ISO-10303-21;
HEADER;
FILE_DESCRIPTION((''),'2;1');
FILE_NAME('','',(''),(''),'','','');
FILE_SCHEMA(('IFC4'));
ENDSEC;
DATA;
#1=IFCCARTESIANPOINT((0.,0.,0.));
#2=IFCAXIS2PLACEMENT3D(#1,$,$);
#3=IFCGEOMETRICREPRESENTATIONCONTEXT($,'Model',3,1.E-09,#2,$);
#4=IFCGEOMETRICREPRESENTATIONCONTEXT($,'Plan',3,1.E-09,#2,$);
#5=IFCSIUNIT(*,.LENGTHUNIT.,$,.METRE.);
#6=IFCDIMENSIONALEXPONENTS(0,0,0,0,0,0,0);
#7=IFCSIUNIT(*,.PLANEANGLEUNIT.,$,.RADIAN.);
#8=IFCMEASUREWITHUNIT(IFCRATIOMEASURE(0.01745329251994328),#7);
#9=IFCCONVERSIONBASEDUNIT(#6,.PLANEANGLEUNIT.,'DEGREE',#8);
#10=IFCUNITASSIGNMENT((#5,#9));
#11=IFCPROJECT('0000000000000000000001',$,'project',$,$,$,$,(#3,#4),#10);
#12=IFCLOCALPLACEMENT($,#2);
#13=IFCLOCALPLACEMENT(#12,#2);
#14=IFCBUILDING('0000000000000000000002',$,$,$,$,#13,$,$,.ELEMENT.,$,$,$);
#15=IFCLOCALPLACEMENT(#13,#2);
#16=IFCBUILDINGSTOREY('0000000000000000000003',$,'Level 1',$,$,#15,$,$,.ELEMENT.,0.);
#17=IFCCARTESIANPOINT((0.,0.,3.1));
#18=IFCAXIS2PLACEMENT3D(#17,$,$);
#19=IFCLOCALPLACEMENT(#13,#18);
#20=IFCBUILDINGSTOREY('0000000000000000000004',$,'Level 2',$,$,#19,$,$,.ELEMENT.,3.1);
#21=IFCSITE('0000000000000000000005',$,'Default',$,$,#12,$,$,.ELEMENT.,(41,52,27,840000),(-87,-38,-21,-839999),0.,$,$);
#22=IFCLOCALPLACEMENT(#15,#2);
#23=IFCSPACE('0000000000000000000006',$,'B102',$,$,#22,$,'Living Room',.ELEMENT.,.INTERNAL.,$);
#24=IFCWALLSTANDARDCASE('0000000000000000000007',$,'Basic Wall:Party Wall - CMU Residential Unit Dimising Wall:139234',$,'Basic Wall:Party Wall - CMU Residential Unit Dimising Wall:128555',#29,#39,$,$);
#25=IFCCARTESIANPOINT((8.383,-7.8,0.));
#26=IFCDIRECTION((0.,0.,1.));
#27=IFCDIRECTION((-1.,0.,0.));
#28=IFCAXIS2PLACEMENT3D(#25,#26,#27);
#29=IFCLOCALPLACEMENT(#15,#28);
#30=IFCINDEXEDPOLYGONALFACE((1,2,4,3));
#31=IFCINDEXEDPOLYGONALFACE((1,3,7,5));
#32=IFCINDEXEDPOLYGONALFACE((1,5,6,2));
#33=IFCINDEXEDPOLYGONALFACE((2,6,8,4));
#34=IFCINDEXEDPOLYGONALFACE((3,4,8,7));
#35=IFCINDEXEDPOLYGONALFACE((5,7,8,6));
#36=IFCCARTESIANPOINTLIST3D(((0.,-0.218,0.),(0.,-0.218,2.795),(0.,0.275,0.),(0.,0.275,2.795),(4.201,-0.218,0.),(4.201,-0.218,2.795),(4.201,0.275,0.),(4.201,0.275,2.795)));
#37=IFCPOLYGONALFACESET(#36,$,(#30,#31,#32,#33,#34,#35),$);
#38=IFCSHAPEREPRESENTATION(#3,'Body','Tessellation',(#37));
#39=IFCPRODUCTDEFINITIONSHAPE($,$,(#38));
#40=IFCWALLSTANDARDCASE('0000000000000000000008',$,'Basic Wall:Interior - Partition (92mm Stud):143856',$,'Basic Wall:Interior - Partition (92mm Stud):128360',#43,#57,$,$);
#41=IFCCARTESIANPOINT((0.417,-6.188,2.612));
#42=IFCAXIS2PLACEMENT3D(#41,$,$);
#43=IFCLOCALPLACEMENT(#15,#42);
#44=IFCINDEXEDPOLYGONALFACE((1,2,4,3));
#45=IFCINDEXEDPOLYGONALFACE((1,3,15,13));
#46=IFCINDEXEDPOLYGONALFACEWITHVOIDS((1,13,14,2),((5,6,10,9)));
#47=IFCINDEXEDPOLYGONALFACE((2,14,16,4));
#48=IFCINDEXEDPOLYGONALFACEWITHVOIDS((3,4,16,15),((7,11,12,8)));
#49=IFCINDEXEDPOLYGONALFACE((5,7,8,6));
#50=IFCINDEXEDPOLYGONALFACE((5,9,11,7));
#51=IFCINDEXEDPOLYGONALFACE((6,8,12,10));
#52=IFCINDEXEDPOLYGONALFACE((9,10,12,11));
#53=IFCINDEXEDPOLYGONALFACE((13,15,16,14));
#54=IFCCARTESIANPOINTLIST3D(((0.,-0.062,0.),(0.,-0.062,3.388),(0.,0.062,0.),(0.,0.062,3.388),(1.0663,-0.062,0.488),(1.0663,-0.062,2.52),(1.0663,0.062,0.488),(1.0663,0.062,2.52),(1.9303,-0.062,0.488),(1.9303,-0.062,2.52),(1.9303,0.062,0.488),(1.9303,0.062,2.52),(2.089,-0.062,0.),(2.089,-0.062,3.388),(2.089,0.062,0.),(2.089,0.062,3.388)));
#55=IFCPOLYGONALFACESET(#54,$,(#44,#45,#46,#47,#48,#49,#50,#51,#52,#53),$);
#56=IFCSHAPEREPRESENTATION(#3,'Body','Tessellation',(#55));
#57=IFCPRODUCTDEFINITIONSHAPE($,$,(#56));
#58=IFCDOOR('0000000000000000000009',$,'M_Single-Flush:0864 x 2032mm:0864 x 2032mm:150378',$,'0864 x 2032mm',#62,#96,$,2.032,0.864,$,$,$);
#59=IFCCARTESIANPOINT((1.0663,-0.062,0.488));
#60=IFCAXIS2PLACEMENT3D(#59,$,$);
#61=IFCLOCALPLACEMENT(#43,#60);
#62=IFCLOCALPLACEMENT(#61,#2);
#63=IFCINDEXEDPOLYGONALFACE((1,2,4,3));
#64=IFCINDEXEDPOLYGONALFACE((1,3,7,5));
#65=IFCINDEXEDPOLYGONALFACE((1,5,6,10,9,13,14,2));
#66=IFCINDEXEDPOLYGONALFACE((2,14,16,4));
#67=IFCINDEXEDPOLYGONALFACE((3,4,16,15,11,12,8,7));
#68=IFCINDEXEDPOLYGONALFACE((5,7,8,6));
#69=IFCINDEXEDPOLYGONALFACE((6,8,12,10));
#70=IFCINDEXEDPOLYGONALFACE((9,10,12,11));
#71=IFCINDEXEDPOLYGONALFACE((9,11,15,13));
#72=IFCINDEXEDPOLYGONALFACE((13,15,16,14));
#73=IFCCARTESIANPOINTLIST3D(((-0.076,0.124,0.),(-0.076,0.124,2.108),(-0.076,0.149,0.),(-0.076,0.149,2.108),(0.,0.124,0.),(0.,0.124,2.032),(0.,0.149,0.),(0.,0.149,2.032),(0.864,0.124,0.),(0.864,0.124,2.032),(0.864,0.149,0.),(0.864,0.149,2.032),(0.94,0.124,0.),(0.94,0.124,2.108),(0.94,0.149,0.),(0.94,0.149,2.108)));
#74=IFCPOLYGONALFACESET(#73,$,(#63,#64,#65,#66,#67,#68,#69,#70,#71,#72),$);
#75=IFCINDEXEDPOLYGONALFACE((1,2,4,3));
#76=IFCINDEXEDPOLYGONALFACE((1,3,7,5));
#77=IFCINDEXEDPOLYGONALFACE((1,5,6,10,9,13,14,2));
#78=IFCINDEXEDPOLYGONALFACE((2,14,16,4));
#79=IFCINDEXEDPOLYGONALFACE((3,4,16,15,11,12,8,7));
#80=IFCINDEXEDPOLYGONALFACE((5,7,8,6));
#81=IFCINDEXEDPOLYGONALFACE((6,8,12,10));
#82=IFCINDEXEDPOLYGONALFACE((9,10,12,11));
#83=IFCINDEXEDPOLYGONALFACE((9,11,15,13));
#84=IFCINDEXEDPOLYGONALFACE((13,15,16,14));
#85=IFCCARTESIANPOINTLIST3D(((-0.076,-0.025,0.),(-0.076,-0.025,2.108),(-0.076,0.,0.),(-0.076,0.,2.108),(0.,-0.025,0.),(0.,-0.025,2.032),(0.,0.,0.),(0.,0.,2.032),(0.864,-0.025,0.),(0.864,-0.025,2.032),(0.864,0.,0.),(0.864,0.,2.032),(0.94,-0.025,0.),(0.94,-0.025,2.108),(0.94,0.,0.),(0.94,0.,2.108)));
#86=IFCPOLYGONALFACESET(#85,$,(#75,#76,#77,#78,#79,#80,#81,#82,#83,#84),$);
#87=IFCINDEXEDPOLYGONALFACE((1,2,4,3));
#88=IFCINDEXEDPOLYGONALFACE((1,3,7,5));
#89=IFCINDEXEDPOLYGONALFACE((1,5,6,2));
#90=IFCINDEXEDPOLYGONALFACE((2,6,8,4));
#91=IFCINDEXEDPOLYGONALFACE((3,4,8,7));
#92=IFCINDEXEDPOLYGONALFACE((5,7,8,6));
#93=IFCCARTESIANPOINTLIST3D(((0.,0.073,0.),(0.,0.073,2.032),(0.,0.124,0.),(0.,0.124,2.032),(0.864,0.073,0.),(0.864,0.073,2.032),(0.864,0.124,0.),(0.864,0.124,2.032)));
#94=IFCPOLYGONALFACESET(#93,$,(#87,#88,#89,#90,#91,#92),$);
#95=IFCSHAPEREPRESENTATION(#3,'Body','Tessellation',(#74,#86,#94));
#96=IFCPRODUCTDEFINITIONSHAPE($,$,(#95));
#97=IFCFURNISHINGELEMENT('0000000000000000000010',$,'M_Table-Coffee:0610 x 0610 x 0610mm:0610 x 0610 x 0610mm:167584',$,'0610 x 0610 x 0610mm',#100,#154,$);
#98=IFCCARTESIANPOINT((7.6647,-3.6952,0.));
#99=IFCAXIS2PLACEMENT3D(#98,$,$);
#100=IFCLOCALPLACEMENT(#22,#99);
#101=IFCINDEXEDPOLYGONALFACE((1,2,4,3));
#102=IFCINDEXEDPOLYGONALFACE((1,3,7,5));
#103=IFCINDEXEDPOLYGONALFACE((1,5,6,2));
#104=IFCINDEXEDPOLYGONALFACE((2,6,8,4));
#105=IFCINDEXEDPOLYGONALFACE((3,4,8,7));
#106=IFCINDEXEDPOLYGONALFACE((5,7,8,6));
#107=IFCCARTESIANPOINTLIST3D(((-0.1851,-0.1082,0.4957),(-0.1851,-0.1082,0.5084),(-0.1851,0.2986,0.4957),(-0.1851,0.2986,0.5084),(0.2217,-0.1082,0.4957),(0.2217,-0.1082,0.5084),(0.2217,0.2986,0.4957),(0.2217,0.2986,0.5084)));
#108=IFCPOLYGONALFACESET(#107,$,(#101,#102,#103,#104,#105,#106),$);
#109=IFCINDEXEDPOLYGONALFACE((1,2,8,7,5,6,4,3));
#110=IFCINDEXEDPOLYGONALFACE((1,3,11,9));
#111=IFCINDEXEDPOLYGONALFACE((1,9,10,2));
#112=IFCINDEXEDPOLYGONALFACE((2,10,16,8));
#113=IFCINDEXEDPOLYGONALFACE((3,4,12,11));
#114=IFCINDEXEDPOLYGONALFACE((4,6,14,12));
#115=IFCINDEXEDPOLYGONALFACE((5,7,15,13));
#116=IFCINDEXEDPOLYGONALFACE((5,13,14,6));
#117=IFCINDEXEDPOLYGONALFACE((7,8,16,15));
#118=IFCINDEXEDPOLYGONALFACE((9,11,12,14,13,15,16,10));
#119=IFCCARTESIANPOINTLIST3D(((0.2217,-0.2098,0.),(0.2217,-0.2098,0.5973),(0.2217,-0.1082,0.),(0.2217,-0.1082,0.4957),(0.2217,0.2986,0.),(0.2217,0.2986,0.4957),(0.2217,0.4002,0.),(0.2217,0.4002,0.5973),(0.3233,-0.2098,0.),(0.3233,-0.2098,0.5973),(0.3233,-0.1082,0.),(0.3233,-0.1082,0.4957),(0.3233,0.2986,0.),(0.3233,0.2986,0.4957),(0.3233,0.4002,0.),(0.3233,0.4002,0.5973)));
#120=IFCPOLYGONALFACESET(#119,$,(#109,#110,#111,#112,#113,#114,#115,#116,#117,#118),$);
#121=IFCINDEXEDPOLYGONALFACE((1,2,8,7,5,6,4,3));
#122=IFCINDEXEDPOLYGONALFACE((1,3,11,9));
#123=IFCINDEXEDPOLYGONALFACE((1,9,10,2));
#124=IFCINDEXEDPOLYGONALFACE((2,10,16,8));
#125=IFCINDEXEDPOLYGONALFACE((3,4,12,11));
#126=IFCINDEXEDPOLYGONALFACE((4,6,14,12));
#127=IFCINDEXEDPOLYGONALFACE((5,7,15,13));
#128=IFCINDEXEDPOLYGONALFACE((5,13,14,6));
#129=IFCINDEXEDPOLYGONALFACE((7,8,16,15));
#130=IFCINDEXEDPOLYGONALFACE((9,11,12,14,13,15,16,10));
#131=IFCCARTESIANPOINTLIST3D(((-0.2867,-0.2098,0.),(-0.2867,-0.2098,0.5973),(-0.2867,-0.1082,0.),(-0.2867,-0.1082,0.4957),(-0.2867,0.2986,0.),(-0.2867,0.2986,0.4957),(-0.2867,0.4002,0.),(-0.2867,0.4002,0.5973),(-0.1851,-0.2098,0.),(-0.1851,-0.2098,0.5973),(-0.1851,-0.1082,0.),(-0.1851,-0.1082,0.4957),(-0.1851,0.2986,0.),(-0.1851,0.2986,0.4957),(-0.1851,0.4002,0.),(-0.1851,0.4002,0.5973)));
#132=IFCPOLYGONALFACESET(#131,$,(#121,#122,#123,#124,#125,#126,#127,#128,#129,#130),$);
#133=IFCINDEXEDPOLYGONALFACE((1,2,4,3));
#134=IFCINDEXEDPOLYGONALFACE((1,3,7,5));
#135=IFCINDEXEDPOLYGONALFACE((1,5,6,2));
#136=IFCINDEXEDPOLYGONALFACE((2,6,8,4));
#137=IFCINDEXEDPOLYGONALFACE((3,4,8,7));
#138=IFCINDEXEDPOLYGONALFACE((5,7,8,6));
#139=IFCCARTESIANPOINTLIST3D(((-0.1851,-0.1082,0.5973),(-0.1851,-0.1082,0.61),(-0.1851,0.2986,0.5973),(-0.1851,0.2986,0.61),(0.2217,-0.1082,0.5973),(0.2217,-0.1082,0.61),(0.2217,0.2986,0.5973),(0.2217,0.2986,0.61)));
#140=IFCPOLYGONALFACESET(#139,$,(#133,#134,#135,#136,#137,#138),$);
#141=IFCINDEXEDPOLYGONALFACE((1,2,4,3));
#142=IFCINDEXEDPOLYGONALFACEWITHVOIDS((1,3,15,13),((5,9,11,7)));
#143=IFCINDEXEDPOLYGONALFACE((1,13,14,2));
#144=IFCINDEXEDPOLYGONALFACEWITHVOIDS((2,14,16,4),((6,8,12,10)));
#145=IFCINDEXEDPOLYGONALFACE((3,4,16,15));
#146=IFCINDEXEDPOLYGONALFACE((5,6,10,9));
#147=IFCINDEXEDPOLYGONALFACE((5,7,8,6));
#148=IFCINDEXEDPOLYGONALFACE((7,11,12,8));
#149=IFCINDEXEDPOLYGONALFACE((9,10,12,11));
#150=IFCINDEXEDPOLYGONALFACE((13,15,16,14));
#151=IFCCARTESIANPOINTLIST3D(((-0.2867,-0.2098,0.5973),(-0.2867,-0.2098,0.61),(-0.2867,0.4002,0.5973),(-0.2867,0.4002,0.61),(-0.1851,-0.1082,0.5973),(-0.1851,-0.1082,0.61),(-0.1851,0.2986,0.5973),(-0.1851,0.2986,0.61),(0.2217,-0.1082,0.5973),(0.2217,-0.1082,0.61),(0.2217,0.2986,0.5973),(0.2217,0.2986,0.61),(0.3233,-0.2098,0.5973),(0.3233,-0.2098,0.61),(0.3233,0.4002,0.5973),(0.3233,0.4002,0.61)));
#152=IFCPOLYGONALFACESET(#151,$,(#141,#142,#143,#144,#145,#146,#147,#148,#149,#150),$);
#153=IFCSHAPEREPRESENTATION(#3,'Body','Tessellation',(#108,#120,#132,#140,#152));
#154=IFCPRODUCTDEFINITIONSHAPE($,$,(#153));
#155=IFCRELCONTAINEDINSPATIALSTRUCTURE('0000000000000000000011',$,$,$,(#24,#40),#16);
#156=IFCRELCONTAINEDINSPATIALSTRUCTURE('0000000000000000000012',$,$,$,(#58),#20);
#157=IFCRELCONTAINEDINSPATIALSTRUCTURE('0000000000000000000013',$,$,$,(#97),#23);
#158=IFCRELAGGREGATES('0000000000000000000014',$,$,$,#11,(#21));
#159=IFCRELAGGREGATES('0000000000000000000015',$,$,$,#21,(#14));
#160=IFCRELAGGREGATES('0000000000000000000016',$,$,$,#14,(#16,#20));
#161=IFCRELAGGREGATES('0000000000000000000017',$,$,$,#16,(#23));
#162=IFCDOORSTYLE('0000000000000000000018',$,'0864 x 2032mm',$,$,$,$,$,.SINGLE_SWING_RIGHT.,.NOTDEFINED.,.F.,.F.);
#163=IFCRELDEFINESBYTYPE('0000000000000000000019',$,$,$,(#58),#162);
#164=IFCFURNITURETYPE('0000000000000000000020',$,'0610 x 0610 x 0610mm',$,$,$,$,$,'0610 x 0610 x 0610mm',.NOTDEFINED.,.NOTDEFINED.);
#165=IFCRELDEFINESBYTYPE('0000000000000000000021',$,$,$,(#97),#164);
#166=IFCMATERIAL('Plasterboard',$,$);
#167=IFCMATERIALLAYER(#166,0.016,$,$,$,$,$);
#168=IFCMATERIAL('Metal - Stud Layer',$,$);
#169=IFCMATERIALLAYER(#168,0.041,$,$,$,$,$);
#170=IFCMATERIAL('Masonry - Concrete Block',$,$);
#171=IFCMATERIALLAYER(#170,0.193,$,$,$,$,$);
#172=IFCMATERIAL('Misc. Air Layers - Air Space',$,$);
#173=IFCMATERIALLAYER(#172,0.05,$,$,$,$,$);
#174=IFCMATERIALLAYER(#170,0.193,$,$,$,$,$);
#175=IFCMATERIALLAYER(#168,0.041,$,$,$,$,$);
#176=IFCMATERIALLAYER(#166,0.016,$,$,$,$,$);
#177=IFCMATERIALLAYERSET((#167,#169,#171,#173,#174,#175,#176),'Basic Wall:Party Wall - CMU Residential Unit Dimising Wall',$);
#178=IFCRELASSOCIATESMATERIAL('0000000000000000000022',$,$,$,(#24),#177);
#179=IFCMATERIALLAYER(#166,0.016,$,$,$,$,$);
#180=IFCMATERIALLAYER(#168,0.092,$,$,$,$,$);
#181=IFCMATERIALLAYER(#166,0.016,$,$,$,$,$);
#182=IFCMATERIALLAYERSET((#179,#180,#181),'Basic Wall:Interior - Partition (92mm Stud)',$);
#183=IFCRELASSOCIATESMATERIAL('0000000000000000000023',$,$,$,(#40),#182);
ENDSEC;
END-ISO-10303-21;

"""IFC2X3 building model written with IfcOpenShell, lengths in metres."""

from ifc_helpers import new_model, entity, si_unit, converted_unit, frame, frame_2d, origin, origin_2d_with_axis, place, context, project, spatial, polyline, rectangle, outline, extrude, clip, bounded_halfspace, source, transform, mapped, material, layer, layer_set, layer_usage, type_object, type_shapes, element, fill, save


model = new_model("IFC2X3")

# Units and contexts
model_context_1 = context("Model", 3, precision=1e-09, world=origin())
plan_context = context("Plan", 3, precision=1e-09, world=origin())
ifc_project = project(units=[si_unit("LENGTHUNIT", "METRE"), converted_unit("PLANEANGLEUNIT", "DEGREE", entity("IfcRatioMeasure", 0.01745329251994328), si_unit("PLANEANGLEUNIT", "RADIAN"), dimensions=[0, 0, 0, 0, 0, 0, 0])], contexts=[model_context_1, plan_context])

# Site, building, storey
site_placement = place(None, origin())
site = spatial("IfcSite", under=ifc_project, at=site_placement, Name="Default", CompositionType="ELEMENT", RefLatitude=(41, 52, 27, 840000), RefLongitude=(-87, -38, -21, -839999), RefElevation=0.0)
building_placement = place(site_placement, origin())
building = spatial("IfcBuilding", under=site, at=building_placement, CompositionType="ELEMENT")
storey_1_placement = place(building_placement, origin())
storey_1 = spatial("IfcBuildingStorey", under=building, at=storey_1_placement, Name="Level 1", CompositionType="ELEMENT", Elevation=0.0)

# Shared definitions
ifc_material_1 = material(Name="Misc. Air Layers - Air Space")
ifc_material_2 = material(Name="Masonry - Concrete Block")
ifc_material_3 = material(Name="Metal - Stud Layer")
ifc_material_4 = material(Name="Plasterboard")

# Shared definitions
ifc_layer_1 = layer(ifc_material_4, 0.016)
ifc_layer_2 = layer(ifc_material_3, 0.092)
ifc_layer_3 = layer(ifc_material_4, 0.016)
ifc_layer_set_1 = layer_set([ifc_layer_1, ifc_layer_2, ifc_layer_3], Name="Basic Wall:Interior - Partition (92mm Stud)")

# Wall
ifc_layer_4 = layer(ifc_material_4, 0.016)
ifc_layer_5 = layer(ifc_material_3, 0.041)
ifc_layer_6 = layer(ifc_material_2, 0.193)
ifc_layer_7 = layer(ifc_material_1, 0.05)
ifc_layer_8 = layer(ifc_material_2, 0.193)
ifc_layer_9 = layer(ifc_material_3, 0.041)
ifc_layer_10 = layer(ifc_material_4, 0.016)
ifc_layer_set_2 = layer_set([ifc_layer_4, ifc_layer_5, ifc_layer_6, ifc_layer_7, ifc_layer_8, ifc_layer_9, ifc_layer_10], Name="Basic Wall:Party Wall - CMU Residential Unit Dimising Wall")
ifc_layer_usage_1 = layer_usage(ifc_layer_set_2, "AXIS2", "NEGATIVE", 0.275)
wall_1_placement = place(storey_1_placement, frame((8.383, -7.8, 0.0), z_axis=(0.0, 0.0, 1.0), x_axis=(-1.0, 0.0, 0.0)))
element("IfcWallStandardCase", 1, at=wall_1_placement, inside=storey_1, material=ifc_layer_usage_1, Name="Basic Wall:Party Wall - CMU Residential Unit Dimising Wall:139234", ObjectType="Basic Wall:Party Wall - CMU Residential Unit Dimising Wall:128555", context=model_context_1, shape_type="Clipping", body=[
    clip(clip(extrude(rectangle(XDim=4.201, YDim=0.55, at=frame_2d((2.1005, 0.0), x_axis=(-1.0, 0.0))), origin(), (0.0, 0.0, 1.0), 2.795), bounded_halfspace(frame((0.0, -0.218, 2.795), z_axis=(0.0, 1.0, 0.0), x_axis=(-1.0, 0.0, 0.0)), True, frame((0.0, -0.218, 2.795), z_axis=(0.0, 1.0, 0.0), x_axis=(-1.0, 0.0, 0.0)), polyline([(0.0, 0.0), (-3.708, 0.0), (-4.201, 0.0), (-4.201, -2.795), (0.0, -2.795), (0.0, 0.0)]))), bounded_halfspace(frame((4.201, 0.275, 0.0), z_axis=(-1.0, 0.0, 0.0), x_axis=(0.0, -1.0, 0.0)), True, frame((4.201, 0.275, 0.0), z_axis=(-1.0, 0.0, 0.0), x_axis=(0.0, -1.0, 0.0)), polyline([(0.0, 0.0), (0.493, 0.0), (0.493, 2.795), (0.0, 2.795), (0.0, 0.0)]))),
])

# Wall, opening
ifc_layer_usage_2 = layer_usage(ifc_layer_set_1, "AXIS2", "NEGATIVE", 0.062)
wall_2_placement = place(storey_1_placement, frame((0.417, -6.188, 2.612)))
wall_2 = element("IfcWallStandardCase", 2, at=wall_2_placement, inside=storey_1, material=ifc_layer_usage_2, Name="Basic Wall:Interior - Partition (92mm Stud):143856", ObjectType="Basic Wall:Interior - Partition (92mm Stud):128360", context=model_context_1, shape_type="SweptSolid", body=[
    extrude(rectangle(XDim=2.089, YDim=0.124, at=frame_2d((1.0445, 0.0), x_axis=(-1.0, 0.0))), origin(), (0.0, 0.0, 1.0), 3.388),
])
opening_1_placement = place(wall_2_placement, frame((1.0663, -0.062, 0.488)))
opening_1 = element("IfcOpeningElement", 3, at=opening_1_placement, cuts=wall_2, ObjectType="Opening", context=model_context_1, shape_type="SweptSolid", body=[
    extrude(rectangle(XDim=0.864, YDim=2.032, at=frame_2d((1.016, 0.432), x_axis=(0.0, 1.0))), frame((0.0, 0.0, 0.0), z_axis=(0.0, 1.0, 0.0), x_axis=(0.0, 0.0, 1.0)), (0.0, 0.0, 1.0), 0.124),
])

# Shared definitions
storey_2_placement = place(building_placement, frame((0.0, 0.0, 3.1)))
storey_2 = spatial("IfcBuildingStorey", under=building, at=storey_2_placement, Name="Level 2", CompositionType="ELEMENT", Elevation=3.1)

# Door
door_style_1 = type_object("IfcDoorStyle", Name="0864 x 2032mm", ConstructionType="NOTDEFINED", OperationType="SINGLE_SWING_RIGHT", ParameterTakesPrecedence=False, Sizeable=False)
shared_shape_1 = source(origin(), model_context_1, "Body", "SweptSolid", [
    extrude(outline(polyline([(-0.508, -1.073), (0.508, -1.073), (0.508, 1.035), (0.432, 1.035), (0.432, -0.997), (-0.432, -0.997), (-0.432, 1.035), (-0.508, 1.035), (-0.508, -1.073)])), frame((0.432, 0.124, 1.035), z_axis=(0.0, 1.0, 0.0), x_axis=(1.0, 0.0, 0.0)), (0.0, 0.0, 1.0), 0.025),
    extrude(outline(polyline([(-1.073, -0.508), (1.035, -0.508), (1.035, -0.432), (-0.997, -0.432), (-0.997, 0.432), (1.035, 0.432), (1.035, 0.508), (-1.073, 0.508), (-1.073, -0.508)])), frame((0.432, -0.025, 1.035), z_axis=(0.0, 1.0, 0.0), x_axis=(0.0, 0.0, -1.0)), (0.0, 0.0, 1.0), 0.025),
    extrude(rectangle(XDim=0.051, YDim=0.864, at=origin_2d_with_axis()), frame((0.432, 0.0985, 0.0), z_axis=(0.0, 0.0, 1.0), x_axis=(0.0, 1.0, 0.0)), (0.0, 0.0, 1.0), 2.032),
])
type_shapes(door_style_1, [shared_shape_1])
door_1_placement = place(opening_1_placement, origin())
door_1 = element("IfcDoor", 4, at=door_1_placement, inside=storey_2, type_object=door_style_1, Name="M_Single-Flush:0864 x 2032mm:0864 x 2032mm:150378", ObjectType="0864 x 2032mm", OverallHeight=2.032, OverallWidth=0.864, context=model_context_1, shape_type="MappedRepresentation", body=[
    mapped(shared_shape_1, transform((0.0, 0.0, 0.0), scale=1.0)),
])
fill(opening_1, door_1)

# Shared definitions
space_1_placement = place(storey_1_placement, origin())
space_1 = spatial("IfcSpace", under=storey_1, at=space_1_placement, Name="B102", LongName="Living Room", CompositionType="ELEMENT", InteriorOrExteriorSpace="INTERNAL")

# Furnishing element
furniture_type_1 = type_object("IfcFurnitureType", Name="0610 x 0610 x 0610mm", ElementType="0610 x 0610 x 0610mm", AssemblyPlace="NOTDEFINED")
shared_shape_2 = source(origin(), model_context_1, "Body", "SweptSolid", [
    extrude(rectangle(XDim=0.4068, YDim=0.4068, at=origin_2d_with_axis()), frame((0.0183, 0.0952, 0.4957), z_axis=(0.0, 0.0, 1.0), x_axis=(-1.0, 0.0, 0.0)), (0.0, 0.0, 1.0), 0.0127),
    extrude(outline(polyline([(-0.2732, -0.305), (0.324, -0.305), (0.324, 0.305), (-0.2732, 0.305), (-0.2732, 0.2034), (0.2225, 0.2034), (0.2225, -0.2034), (-0.2732, -0.2034), (-0.2732, -0.305)])), frame((0.2217, 0.0952, 0.2732), z_axis=(1.0, 0.0, 0.0), x_axis=(0.0, 0.0, 1.0)), (0.0, 0.0, 1.0), 0.1016),
    extrude(outline(polyline([(-0.305, -0.3241), (0.305, -0.3241), (0.305, 0.2733), (0.2034, 0.2733), (0.2034, -0.2224), (-0.2034, -0.2224), (-0.2034, 0.2733), (-0.305, 0.2733), (-0.305, -0.3241)])), frame((-0.2867, 0.0952, 0.2733), z_axis=(1.0, 0.0, 0.0), x_axis=(0.0, -1.0, 0.0)), (0.0, 0.0, 1.0), 0.1016),
    extrude(rectangle(XDim=0.4068, YDim=0.4068, at=origin_2d_with_axis()), frame((0.0183, 0.0952, 0.5973), z_axis=(0.0, 0.0, 1.0), x_axis=(-1.0, 0.0, 0.0)), (0.0, 0.0, 1.0), 0.0127),
    extrude(outline(polyline([(-0.305, -0.305), (0.305, -0.305), (0.305, 0.305), (-0.305, 0.305), (-0.305, -0.305)]), holes=[polyline([(-0.2034, -0.2034), (-0.2034, 0.2034), (0.2034, 0.2034), (0.2034, -0.2034), (-0.2034, -0.2034)])]), frame((0.0183, 0.0952, 0.5973), z_axis=(0.0, 0.0, 1.0), x_axis=(-1.0, 0.0, 0.0)), (0.0, 0.0, 1.0), 0.0127),
])
type_shapes(furniture_type_1, [shared_shape_2])
for number, where, name in (
    (5, (7.6647, -3.6952, 0.0), "M_Table-Coffee:0610 x 0610 x 0610mm:0610 x 0610 x 0610mm:167584"),
):
    element("IfcFurnishingElement", number, at=place(space_1_placement, frame(where)), inside=space_1, type_object=furniture_type_1, Name=name, ObjectType="0610 x 0610 x 0610mm", context=model_context_1, shape_type="MappedRepresentation", body=[
        mapped(shared_shape_2, transform((0.0, 0.0, 0.0), scale=1.0)),
    ])

save(model, "model.ifc")
